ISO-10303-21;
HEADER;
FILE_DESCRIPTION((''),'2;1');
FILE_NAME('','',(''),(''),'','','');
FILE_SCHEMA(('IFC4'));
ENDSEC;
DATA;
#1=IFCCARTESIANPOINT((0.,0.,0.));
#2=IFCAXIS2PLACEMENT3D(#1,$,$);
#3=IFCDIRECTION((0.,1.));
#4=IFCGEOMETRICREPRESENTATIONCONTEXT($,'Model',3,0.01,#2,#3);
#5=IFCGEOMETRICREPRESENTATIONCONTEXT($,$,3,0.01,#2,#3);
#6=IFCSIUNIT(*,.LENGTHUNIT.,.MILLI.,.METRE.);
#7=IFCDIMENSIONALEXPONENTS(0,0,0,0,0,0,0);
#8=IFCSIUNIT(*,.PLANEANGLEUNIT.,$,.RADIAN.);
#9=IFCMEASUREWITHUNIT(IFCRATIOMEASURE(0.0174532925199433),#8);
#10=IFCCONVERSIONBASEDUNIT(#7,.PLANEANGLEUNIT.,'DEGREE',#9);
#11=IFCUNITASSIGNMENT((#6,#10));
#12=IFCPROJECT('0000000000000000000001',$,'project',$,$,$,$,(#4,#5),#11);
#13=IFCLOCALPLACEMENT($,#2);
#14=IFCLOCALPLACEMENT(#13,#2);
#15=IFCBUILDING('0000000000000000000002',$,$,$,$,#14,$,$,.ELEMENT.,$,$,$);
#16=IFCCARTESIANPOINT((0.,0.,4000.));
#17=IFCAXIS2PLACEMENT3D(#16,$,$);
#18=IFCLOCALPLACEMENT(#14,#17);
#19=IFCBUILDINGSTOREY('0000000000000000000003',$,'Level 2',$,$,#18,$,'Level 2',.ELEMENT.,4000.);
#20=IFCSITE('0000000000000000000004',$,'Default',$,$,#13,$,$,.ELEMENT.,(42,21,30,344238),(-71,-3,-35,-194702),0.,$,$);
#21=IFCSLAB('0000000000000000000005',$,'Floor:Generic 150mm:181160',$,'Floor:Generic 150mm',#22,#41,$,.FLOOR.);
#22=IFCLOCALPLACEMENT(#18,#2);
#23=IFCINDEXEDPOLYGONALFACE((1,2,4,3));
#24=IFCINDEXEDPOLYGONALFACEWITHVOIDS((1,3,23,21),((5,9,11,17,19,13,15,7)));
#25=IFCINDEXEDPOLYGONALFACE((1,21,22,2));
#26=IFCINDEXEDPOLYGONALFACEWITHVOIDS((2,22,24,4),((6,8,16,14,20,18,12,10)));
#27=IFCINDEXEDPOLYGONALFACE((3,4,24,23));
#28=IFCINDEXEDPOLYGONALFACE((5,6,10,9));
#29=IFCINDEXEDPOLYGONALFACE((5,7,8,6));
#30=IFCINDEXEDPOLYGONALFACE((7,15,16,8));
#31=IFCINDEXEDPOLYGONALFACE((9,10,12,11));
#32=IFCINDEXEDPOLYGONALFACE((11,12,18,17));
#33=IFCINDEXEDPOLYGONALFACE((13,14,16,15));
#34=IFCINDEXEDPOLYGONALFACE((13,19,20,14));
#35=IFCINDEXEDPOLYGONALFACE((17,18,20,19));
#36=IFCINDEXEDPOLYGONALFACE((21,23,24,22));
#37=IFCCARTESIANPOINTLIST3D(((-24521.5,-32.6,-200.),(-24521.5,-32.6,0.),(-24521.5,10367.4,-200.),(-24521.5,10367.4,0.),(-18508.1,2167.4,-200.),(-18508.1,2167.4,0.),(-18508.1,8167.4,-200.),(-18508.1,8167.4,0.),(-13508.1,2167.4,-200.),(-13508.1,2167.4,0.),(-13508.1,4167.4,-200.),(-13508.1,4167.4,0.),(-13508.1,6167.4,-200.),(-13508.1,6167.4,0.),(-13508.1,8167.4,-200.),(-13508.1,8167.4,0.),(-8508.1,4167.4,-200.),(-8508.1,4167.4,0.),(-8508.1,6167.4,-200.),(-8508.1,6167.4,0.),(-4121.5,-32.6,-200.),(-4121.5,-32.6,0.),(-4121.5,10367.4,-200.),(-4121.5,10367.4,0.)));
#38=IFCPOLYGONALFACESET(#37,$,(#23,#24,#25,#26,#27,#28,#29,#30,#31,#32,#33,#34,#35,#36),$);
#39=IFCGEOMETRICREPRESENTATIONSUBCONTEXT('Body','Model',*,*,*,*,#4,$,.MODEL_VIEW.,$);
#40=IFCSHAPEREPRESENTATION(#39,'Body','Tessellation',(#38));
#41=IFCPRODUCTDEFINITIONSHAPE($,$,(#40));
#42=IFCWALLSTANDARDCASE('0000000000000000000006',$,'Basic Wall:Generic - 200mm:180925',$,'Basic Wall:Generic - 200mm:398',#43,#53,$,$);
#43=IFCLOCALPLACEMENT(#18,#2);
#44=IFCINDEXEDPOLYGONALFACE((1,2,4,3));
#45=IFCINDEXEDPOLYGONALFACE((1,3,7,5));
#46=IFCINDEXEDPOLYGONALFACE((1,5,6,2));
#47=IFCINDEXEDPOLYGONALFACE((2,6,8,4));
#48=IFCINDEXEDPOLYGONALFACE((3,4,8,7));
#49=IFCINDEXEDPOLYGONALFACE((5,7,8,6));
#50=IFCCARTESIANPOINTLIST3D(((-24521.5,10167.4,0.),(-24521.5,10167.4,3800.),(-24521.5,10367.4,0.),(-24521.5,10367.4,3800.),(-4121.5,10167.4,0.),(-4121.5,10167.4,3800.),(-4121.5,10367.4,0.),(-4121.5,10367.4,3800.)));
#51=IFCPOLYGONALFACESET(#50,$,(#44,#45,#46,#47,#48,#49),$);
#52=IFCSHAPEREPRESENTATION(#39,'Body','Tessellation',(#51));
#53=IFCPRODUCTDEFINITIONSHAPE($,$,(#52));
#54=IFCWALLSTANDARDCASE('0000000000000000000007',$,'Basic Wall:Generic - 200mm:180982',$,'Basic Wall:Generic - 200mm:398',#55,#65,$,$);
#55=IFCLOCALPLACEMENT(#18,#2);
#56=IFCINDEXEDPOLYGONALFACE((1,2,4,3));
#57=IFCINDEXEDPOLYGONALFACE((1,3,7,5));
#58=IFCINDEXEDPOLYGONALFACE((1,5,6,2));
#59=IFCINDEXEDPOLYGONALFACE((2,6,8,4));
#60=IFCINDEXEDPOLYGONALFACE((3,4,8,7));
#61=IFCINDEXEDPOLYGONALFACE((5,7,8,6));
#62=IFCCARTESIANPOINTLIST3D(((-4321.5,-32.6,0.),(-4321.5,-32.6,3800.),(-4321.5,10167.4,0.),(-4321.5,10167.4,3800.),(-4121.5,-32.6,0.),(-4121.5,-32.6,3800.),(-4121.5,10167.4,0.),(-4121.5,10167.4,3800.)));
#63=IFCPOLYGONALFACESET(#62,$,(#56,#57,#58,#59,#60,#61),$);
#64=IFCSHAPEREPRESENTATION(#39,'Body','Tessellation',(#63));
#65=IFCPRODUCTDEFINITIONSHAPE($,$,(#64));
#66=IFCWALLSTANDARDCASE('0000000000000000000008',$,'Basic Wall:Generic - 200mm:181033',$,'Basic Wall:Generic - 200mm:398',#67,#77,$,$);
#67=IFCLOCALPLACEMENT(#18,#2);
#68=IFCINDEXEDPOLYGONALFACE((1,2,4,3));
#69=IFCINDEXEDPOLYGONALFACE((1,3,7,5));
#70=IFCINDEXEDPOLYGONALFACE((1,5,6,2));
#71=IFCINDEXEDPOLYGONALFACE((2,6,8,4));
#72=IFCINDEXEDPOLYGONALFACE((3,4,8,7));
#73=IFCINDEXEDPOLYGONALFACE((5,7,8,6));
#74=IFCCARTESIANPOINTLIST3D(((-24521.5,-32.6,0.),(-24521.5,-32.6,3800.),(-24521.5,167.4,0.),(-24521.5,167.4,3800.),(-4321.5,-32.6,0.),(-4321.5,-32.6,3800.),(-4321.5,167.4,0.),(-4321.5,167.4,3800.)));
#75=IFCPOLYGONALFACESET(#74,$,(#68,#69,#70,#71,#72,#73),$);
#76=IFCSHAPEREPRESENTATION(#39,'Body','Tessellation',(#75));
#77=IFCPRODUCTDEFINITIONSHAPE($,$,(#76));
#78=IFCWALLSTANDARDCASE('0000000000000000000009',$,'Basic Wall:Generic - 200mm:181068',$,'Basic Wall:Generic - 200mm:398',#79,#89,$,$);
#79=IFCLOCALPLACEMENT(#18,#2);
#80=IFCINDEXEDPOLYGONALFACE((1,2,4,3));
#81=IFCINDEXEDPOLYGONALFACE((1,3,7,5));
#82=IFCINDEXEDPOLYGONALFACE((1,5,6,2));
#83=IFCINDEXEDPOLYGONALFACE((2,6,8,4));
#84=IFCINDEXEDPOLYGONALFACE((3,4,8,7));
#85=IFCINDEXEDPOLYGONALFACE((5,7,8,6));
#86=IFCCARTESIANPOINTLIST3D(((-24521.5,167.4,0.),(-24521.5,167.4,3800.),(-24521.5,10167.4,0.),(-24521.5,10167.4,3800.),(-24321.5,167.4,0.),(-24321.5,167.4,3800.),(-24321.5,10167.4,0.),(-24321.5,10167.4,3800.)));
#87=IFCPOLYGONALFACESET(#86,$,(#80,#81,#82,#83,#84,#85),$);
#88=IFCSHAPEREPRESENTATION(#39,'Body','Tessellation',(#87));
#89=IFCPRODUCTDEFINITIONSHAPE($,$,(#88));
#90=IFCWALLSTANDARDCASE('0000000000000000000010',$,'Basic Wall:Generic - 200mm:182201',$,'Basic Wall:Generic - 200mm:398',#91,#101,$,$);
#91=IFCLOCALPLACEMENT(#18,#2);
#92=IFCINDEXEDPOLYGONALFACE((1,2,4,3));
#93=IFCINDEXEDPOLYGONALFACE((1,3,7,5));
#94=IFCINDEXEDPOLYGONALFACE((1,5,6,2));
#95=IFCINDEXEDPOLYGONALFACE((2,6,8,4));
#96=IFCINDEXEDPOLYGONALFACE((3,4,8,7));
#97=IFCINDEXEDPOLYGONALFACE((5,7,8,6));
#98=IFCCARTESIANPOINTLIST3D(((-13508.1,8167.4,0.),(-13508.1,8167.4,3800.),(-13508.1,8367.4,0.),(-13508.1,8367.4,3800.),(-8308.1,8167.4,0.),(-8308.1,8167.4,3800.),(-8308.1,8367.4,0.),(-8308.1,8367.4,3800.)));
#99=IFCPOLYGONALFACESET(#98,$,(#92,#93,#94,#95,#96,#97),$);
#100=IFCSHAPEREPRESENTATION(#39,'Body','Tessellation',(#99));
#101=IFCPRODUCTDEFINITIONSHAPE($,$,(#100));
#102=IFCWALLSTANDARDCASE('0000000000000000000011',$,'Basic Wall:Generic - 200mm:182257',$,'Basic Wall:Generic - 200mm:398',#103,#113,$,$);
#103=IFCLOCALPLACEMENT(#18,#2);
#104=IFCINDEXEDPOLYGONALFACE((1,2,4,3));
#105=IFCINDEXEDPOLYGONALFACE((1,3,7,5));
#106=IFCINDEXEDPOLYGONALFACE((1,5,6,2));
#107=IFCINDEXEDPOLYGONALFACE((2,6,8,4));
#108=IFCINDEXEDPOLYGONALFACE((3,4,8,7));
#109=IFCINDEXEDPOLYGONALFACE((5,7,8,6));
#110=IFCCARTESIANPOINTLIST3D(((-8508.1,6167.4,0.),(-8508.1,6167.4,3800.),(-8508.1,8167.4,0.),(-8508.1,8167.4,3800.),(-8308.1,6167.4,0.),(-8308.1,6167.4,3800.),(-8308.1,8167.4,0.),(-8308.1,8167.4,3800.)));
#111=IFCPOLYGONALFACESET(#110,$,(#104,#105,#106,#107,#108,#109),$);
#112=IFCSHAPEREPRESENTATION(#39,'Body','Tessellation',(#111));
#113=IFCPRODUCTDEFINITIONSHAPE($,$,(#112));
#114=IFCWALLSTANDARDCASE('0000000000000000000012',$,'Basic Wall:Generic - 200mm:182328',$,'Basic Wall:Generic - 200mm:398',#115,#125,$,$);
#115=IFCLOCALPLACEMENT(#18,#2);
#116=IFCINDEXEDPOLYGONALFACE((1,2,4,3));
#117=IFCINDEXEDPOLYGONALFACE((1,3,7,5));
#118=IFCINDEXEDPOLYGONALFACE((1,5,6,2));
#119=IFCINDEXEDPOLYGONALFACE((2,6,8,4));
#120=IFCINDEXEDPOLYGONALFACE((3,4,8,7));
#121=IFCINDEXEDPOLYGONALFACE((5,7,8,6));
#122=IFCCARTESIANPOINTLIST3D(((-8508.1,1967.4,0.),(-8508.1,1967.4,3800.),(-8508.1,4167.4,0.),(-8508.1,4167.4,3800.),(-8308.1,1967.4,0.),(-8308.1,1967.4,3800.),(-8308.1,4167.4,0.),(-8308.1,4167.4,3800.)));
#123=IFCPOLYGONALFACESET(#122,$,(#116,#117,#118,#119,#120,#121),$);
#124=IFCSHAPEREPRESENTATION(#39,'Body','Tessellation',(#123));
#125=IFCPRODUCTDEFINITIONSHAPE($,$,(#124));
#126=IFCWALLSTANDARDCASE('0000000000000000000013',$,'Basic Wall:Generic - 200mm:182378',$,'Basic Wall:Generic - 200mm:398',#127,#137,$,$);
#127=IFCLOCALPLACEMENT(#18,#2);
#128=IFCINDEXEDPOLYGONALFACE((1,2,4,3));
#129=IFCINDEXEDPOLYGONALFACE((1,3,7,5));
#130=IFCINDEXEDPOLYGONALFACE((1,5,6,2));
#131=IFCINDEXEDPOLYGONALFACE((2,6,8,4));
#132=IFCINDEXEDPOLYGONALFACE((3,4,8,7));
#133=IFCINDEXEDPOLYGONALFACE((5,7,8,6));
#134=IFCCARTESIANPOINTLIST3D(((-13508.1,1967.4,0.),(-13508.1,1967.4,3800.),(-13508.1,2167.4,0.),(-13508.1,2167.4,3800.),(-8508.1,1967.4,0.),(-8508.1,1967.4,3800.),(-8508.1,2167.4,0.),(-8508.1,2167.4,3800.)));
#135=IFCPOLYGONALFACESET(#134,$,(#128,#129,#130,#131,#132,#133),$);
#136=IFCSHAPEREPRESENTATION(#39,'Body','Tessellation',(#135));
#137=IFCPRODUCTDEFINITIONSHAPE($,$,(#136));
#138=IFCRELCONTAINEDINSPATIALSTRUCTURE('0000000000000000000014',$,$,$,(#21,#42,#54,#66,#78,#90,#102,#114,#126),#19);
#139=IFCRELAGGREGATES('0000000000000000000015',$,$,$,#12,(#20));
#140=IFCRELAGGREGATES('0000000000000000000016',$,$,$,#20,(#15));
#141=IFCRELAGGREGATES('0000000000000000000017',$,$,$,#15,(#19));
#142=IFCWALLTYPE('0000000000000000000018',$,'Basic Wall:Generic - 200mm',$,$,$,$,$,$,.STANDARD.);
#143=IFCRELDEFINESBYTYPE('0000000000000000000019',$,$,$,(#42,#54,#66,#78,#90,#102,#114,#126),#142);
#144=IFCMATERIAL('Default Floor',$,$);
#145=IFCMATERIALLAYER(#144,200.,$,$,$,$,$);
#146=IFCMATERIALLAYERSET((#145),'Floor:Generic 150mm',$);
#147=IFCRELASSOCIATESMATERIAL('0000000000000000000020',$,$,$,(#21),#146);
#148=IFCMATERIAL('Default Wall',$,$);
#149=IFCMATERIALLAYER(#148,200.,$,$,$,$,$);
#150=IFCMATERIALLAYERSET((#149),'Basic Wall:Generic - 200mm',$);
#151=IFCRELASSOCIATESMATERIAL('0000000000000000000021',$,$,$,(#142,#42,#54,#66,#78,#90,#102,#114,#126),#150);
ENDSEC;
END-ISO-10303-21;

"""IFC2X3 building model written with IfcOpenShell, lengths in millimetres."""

from ifc_helpers import new_model, entity, si_unit, converted_unit, direction, frame, frame_2d, origin, place, context, subcontext, project, spatial, polyline, rectangle, outline, extrude, material, layer, layer_set, layer_usage, type_object, element, save


model = new_model("IFC2X3")

# Units and contexts
model_context = context("Model", 3, precision=0.01, world=origin(), true_north=direction((0.0, 1.0)))
context_of_model = context(None, 3, precision=0.01, world=origin(), true_north=direction((0.0, 1.0)))
body_context = subcontext(model_context, "Body", "Model", "MODEL_VIEW")
ifc_project = project(units=[si_unit("LENGTHUNIT", "METRE", prefix="MILLI"), converted_unit("PLANEANGLEUNIT", "DEGREE", entity("IfcRatioMeasure", 0.0174532925199433), si_unit("PLANEANGLEUNIT", "RADIAN"), dimensions=[0, 0, 0, 0, 0, 0, 0])], contexts=[model_context, context_of_model])

# Site, building, storey
site_placement = place(None, origin())
site = spatial("IfcSite", under=ifc_project, at=site_placement, Name="Default", CompositionType="ELEMENT", RefLatitude=(42, 21, 30, 344238), RefLongitude=(-71, -3, -35, -194702), RefElevation=0.0)
building_placement = place(site_placement, origin())
building = spatial("IfcBuilding", under=site, at=building_placement, CompositionType="ELEMENT")
storey_placement = place(building_placement, frame((0.0, 0.0, 4000.0)))
storey = spatial("IfcBuildingStorey", under=building, at=storey_placement, Name="Level 2", LongName="Level 2", CompositionType="ELEMENT", Elevation=4000.0)

# Slab, opening
ifc_material_1 = material(Name="Default Floor")
ifc_layer_1 = layer(ifc_material_1, 200.0)
ifc_layer_set_1 = layer_set([ifc_layer_1], Name="Floor:Generic 150mm")
ifc_layer_usage_1 = layer_usage(ifc_layer_set_1, "AXIS3", "POSITIVE", 0.0)
slab_placement = place(storey_placement, frame((-24521.5, -32.6, -200.0)))
slab = element("IfcSlab", 1, at=slab_placement, inside=storey, material=ifc_layer_usage_1, Name="Floor:Generic 150mm:181160", ObjectType="Floor:Generic 150mm", PredefinedType="FLOOR", context=body_context, shape_type="SweptSolid", body=[
    extrude(rectangle(XDim=10400.0, YDim=20400.0, at=frame_2d((0.0, 0.0), x_axis=(0.0, -1.0))), frame((10200.0, 5200.0, 200.0), z_axis=(0.0, 0.0, -1.0), x_axis=(-1.0, 0.0, 0.0)), (0.0, 0.0, 1.0), 200.0),
])
opening_placement = place(slab_placement, frame((11013.4, 5200.0, 200.0)))
element("IfcOpeningElement", 2, at=opening_placement, cuts=slab, ObjectType="Opening", context=body_context, shape_type="SweptSolid", body=[
    extrude(outline(polyline([(-5000.0, 3000.0), (-5000.0, -3000.0), (0.0, -3000.0), (0.0, -1000.0), (5000.0, -1000.0), (5000.0, 1000.0), (0.0, 1000.0), (0.0, 3000.0), (-5000.0, 3000.0)])), origin(), (0.0, 0.0, -1.0), 200.0),
])

# Walls
ifc_material_2 = material(Name="Default Wall")
ifc_layer_2 = layer(ifc_material_2, 200.0)
ifc_layer_set_2 = layer_set([ifc_layer_2], Name="Basic Wall:Generic - 200mm")
ifc_layer_usage_2 = layer_usage(ifc_layer_set_2, "AXIS2", "NEGATIVE", 100.0)
wall_type = type_object("IfcWallType", Name="Basic Wall:Generic - 200mm", PredefinedType="STANDARD", material=ifc_layer_set_2)
wall_1_placement = place(storey_placement, frame((-24521.5, 10267.4, 0.0)))
element("IfcWallStandardCase", 3, at=wall_1_placement, inside=storey, type_object=wall_type, material=ifc_layer_usage_2, Name="Basic Wall:Generic - 200mm:180925", ObjectType="Basic Wall:Generic - 200mm:398", context=body_context, shape_type="SweptSolid", body=[
    extrude(rectangle(XDim=20400.0, YDim=200.0, at=frame_2d((10200.0, 0.0), x_axis=(-1.0, 0.0))), origin(), (0.0, 0.0, 1.0), 3800.0),
])
ifc_layer_usage_3 = layer_usage(ifc_layer_set_2, "AXIS2", "NEGATIVE", 100.0)
wall_2_placement = place(storey_placement, frame((-4221.5, 10167.4, 0.0), z_axis=(0.0, 0.0, 1.0), x_axis=(0.0, -1.0, 0.0)))
element("IfcWallStandardCase", 4, at=wall_2_placement, inside=storey, type_object=wall_type, material=ifc_layer_usage_3, Name="Basic Wall:Generic - 200mm:180982", ObjectType="Basic Wall:Generic - 200mm:398", context=body_context, shape_type="SweptSolid", body=[
    extrude(rectangle(XDim=10200.0, YDim=200.0, at=frame_2d((5100.0, 0.0), x_axis=(-1.0, 0.0))), origin(), (0.0, 0.0, 1.0), 3800.0),
])
ifc_layer_usage_4 = layer_usage(ifc_layer_set_2, "AXIS2", "NEGATIVE", 100.0)
wall_3_placement = place(storey_placement, frame((-4321.5, 67.4, 0.0), z_axis=(0.0, 0.0, 1.0), x_axis=(-1.0, 0.0, 0.0)))
element("IfcWallStandardCase", 5, at=wall_3_placement, inside=storey, type_object=wall_type, material=ifc_layer_usage_4, Name="Basic Wall:Generic - 200mm:181033", ObjectType="Basic Wall:Generic - 200mm:398", context=body_context, shape_type="SweptSolid", body=[
    extrude(rectangle(XDim=20200.0, YDim=200.0, at=frame_2d((10100.0, 0.0), x_axis=(-1.0, 0.0))), origin(), (0.0, 0.0, 1.0), 3800.0),
])
ifc_layer_usage_5 = layer_usage(ifc_layer_set_2, "AXIS2", "NEGATIVE", 100.0)
wall_4_placement = place(storey_placement, frame((-24421.5, 167.4, 0.0), z_axis=(0.0, 0.0, 1.0), x_axis=(0.0, 1.0, 0.0)))
element("IfcWallStandardCase", 6, at=wall_4_placement, inside=storey, type_object=wall_type, material=ifc_layer_usage_5, Name="Basic Wall:Generic - 200mm:181068", ObjectType="Basic Wall:Generic - 200mm:398", context=body_context, shape_type="SweptSolid", body=[
    extrude(rectangle(XDim=10000.0, YDim=200.0, at=frame_2d((5000.0, 0.0), x_axis=(-1.0, 0.0))), origin(), (0.0, 0.0, 1.0), 3800.0),
])
ifc_layer_usage_6 = layer_usage(ifc_layer_set_2, "AXIS2", "NEGATIVE", 100.0)
wall_5_placement = place(storey_placement, frame((-13508.1, 8267.4, 0.0)))
element("IfcWallStandardCase", 7, at=wall_5_placement, inside=storey, type_object=wall_type, material=ifc_layer_usage_6, Name="Basic Wall:Generic - 200mm:182201", ObjectType="Basic Wall:Generic - 200mm:398", context=body_context, shape_type="SweptSolid", body=[
    extrude(rectangle(XDim=5200.0, YDim=200.0, at=frame_2d((2600.0, 0.0), x_axis=(-1.0, 0.0))), origin(), (0.0, 0.0, 1.0), 3800.0),
])
ifc_layer_usage_7 = layer_usage(ifc_layer_set_2, "AXIS2", "NEGATIVE", 100.0)
wall_6_placement = place(storey_placement, frame((-8408.1, 8167.4, 0.0), z_axis=(0.0, 0.0, 1.0), x_axis=(0.0, -1.0, 0.0)))
element("IfcWallStandardCase", 8, at=wall_6_placement, inside=storey, type_object=wall_type, material=ifc_layer_usage_7, Name="Basic Wall:Generic - 200mm:182257", ObjectType="Basic Wall:Generic - 200mm:398", context=body_context, shape_type="SweptSolid", body=[
    extrude(rectangle(XDim=2000.0, YDim=200.0, at=frame_2d((1000.0, 0.0), x_axis=(-1.0, 0.0))), origin(), (0.0, 0.0, 1.0), 3800.0),
])
ifc_layer_usage_8 = layer_usage(ifc_layer_set_2, "AXIS2", "NEGATIVE", 100.0)
wall_7_placement = place(storey_placement, frame((-8408.1, 4167.4, 0.0), z_axis=(0.0, 0.0, 1.0), x_axis=(0.0, -1.0, 0.0)))
element("IfcWallStandardCase", 9, at=wall_7_placement, inside=storey, type_object=wall_type, material=ifc_layer_usage_8, Name="Basic Wall:Generic - 200mm:182328", ObjectType="Basic Wall:Generic - 200mm:398", context=body_context, shape_type="SweptSolid", body=[
    extrude(rectangle(XDim=2200.0, YDim=200.0, at=frame_2d((1100.0, 0.0), x_axis=(-1.0, 0.0))), origin(), (0.0, 0.0, 1.0), 3800.0),
])
ifc_layer_usage_9 = layer_usage(ifc_layer_set_2, "AXIS2", "NEGATIVE", 100.0)
wall_8_placement = place(storey_placement, frame((-8508.1, 2067.4, 0.0), z_axis=(0.0, 0.0, 1.0), x_axis=(-1.0, 0.0, 0.0)))
element("IfcWallStandardCase", 10, at=wall_8_placement, inside=storey, type_object=wall_type, material=ifc_layer_usage_9, Name="Basic Wall:Generic - 200mm:182378", ObjectType="Basic Wall:Generic - 200mm:398", context=body_context, shape_type="SweptSolid", body=[
    extrude(rectangle(XDim=5000.0, YDim=200.0, at=frame_2d((2500.0, 0.0), x_axis=(-1.0, 0.0))), origin(), (0.0, 0.0, 1.0), 3800.0),
])

save(model, "model.ifc")
